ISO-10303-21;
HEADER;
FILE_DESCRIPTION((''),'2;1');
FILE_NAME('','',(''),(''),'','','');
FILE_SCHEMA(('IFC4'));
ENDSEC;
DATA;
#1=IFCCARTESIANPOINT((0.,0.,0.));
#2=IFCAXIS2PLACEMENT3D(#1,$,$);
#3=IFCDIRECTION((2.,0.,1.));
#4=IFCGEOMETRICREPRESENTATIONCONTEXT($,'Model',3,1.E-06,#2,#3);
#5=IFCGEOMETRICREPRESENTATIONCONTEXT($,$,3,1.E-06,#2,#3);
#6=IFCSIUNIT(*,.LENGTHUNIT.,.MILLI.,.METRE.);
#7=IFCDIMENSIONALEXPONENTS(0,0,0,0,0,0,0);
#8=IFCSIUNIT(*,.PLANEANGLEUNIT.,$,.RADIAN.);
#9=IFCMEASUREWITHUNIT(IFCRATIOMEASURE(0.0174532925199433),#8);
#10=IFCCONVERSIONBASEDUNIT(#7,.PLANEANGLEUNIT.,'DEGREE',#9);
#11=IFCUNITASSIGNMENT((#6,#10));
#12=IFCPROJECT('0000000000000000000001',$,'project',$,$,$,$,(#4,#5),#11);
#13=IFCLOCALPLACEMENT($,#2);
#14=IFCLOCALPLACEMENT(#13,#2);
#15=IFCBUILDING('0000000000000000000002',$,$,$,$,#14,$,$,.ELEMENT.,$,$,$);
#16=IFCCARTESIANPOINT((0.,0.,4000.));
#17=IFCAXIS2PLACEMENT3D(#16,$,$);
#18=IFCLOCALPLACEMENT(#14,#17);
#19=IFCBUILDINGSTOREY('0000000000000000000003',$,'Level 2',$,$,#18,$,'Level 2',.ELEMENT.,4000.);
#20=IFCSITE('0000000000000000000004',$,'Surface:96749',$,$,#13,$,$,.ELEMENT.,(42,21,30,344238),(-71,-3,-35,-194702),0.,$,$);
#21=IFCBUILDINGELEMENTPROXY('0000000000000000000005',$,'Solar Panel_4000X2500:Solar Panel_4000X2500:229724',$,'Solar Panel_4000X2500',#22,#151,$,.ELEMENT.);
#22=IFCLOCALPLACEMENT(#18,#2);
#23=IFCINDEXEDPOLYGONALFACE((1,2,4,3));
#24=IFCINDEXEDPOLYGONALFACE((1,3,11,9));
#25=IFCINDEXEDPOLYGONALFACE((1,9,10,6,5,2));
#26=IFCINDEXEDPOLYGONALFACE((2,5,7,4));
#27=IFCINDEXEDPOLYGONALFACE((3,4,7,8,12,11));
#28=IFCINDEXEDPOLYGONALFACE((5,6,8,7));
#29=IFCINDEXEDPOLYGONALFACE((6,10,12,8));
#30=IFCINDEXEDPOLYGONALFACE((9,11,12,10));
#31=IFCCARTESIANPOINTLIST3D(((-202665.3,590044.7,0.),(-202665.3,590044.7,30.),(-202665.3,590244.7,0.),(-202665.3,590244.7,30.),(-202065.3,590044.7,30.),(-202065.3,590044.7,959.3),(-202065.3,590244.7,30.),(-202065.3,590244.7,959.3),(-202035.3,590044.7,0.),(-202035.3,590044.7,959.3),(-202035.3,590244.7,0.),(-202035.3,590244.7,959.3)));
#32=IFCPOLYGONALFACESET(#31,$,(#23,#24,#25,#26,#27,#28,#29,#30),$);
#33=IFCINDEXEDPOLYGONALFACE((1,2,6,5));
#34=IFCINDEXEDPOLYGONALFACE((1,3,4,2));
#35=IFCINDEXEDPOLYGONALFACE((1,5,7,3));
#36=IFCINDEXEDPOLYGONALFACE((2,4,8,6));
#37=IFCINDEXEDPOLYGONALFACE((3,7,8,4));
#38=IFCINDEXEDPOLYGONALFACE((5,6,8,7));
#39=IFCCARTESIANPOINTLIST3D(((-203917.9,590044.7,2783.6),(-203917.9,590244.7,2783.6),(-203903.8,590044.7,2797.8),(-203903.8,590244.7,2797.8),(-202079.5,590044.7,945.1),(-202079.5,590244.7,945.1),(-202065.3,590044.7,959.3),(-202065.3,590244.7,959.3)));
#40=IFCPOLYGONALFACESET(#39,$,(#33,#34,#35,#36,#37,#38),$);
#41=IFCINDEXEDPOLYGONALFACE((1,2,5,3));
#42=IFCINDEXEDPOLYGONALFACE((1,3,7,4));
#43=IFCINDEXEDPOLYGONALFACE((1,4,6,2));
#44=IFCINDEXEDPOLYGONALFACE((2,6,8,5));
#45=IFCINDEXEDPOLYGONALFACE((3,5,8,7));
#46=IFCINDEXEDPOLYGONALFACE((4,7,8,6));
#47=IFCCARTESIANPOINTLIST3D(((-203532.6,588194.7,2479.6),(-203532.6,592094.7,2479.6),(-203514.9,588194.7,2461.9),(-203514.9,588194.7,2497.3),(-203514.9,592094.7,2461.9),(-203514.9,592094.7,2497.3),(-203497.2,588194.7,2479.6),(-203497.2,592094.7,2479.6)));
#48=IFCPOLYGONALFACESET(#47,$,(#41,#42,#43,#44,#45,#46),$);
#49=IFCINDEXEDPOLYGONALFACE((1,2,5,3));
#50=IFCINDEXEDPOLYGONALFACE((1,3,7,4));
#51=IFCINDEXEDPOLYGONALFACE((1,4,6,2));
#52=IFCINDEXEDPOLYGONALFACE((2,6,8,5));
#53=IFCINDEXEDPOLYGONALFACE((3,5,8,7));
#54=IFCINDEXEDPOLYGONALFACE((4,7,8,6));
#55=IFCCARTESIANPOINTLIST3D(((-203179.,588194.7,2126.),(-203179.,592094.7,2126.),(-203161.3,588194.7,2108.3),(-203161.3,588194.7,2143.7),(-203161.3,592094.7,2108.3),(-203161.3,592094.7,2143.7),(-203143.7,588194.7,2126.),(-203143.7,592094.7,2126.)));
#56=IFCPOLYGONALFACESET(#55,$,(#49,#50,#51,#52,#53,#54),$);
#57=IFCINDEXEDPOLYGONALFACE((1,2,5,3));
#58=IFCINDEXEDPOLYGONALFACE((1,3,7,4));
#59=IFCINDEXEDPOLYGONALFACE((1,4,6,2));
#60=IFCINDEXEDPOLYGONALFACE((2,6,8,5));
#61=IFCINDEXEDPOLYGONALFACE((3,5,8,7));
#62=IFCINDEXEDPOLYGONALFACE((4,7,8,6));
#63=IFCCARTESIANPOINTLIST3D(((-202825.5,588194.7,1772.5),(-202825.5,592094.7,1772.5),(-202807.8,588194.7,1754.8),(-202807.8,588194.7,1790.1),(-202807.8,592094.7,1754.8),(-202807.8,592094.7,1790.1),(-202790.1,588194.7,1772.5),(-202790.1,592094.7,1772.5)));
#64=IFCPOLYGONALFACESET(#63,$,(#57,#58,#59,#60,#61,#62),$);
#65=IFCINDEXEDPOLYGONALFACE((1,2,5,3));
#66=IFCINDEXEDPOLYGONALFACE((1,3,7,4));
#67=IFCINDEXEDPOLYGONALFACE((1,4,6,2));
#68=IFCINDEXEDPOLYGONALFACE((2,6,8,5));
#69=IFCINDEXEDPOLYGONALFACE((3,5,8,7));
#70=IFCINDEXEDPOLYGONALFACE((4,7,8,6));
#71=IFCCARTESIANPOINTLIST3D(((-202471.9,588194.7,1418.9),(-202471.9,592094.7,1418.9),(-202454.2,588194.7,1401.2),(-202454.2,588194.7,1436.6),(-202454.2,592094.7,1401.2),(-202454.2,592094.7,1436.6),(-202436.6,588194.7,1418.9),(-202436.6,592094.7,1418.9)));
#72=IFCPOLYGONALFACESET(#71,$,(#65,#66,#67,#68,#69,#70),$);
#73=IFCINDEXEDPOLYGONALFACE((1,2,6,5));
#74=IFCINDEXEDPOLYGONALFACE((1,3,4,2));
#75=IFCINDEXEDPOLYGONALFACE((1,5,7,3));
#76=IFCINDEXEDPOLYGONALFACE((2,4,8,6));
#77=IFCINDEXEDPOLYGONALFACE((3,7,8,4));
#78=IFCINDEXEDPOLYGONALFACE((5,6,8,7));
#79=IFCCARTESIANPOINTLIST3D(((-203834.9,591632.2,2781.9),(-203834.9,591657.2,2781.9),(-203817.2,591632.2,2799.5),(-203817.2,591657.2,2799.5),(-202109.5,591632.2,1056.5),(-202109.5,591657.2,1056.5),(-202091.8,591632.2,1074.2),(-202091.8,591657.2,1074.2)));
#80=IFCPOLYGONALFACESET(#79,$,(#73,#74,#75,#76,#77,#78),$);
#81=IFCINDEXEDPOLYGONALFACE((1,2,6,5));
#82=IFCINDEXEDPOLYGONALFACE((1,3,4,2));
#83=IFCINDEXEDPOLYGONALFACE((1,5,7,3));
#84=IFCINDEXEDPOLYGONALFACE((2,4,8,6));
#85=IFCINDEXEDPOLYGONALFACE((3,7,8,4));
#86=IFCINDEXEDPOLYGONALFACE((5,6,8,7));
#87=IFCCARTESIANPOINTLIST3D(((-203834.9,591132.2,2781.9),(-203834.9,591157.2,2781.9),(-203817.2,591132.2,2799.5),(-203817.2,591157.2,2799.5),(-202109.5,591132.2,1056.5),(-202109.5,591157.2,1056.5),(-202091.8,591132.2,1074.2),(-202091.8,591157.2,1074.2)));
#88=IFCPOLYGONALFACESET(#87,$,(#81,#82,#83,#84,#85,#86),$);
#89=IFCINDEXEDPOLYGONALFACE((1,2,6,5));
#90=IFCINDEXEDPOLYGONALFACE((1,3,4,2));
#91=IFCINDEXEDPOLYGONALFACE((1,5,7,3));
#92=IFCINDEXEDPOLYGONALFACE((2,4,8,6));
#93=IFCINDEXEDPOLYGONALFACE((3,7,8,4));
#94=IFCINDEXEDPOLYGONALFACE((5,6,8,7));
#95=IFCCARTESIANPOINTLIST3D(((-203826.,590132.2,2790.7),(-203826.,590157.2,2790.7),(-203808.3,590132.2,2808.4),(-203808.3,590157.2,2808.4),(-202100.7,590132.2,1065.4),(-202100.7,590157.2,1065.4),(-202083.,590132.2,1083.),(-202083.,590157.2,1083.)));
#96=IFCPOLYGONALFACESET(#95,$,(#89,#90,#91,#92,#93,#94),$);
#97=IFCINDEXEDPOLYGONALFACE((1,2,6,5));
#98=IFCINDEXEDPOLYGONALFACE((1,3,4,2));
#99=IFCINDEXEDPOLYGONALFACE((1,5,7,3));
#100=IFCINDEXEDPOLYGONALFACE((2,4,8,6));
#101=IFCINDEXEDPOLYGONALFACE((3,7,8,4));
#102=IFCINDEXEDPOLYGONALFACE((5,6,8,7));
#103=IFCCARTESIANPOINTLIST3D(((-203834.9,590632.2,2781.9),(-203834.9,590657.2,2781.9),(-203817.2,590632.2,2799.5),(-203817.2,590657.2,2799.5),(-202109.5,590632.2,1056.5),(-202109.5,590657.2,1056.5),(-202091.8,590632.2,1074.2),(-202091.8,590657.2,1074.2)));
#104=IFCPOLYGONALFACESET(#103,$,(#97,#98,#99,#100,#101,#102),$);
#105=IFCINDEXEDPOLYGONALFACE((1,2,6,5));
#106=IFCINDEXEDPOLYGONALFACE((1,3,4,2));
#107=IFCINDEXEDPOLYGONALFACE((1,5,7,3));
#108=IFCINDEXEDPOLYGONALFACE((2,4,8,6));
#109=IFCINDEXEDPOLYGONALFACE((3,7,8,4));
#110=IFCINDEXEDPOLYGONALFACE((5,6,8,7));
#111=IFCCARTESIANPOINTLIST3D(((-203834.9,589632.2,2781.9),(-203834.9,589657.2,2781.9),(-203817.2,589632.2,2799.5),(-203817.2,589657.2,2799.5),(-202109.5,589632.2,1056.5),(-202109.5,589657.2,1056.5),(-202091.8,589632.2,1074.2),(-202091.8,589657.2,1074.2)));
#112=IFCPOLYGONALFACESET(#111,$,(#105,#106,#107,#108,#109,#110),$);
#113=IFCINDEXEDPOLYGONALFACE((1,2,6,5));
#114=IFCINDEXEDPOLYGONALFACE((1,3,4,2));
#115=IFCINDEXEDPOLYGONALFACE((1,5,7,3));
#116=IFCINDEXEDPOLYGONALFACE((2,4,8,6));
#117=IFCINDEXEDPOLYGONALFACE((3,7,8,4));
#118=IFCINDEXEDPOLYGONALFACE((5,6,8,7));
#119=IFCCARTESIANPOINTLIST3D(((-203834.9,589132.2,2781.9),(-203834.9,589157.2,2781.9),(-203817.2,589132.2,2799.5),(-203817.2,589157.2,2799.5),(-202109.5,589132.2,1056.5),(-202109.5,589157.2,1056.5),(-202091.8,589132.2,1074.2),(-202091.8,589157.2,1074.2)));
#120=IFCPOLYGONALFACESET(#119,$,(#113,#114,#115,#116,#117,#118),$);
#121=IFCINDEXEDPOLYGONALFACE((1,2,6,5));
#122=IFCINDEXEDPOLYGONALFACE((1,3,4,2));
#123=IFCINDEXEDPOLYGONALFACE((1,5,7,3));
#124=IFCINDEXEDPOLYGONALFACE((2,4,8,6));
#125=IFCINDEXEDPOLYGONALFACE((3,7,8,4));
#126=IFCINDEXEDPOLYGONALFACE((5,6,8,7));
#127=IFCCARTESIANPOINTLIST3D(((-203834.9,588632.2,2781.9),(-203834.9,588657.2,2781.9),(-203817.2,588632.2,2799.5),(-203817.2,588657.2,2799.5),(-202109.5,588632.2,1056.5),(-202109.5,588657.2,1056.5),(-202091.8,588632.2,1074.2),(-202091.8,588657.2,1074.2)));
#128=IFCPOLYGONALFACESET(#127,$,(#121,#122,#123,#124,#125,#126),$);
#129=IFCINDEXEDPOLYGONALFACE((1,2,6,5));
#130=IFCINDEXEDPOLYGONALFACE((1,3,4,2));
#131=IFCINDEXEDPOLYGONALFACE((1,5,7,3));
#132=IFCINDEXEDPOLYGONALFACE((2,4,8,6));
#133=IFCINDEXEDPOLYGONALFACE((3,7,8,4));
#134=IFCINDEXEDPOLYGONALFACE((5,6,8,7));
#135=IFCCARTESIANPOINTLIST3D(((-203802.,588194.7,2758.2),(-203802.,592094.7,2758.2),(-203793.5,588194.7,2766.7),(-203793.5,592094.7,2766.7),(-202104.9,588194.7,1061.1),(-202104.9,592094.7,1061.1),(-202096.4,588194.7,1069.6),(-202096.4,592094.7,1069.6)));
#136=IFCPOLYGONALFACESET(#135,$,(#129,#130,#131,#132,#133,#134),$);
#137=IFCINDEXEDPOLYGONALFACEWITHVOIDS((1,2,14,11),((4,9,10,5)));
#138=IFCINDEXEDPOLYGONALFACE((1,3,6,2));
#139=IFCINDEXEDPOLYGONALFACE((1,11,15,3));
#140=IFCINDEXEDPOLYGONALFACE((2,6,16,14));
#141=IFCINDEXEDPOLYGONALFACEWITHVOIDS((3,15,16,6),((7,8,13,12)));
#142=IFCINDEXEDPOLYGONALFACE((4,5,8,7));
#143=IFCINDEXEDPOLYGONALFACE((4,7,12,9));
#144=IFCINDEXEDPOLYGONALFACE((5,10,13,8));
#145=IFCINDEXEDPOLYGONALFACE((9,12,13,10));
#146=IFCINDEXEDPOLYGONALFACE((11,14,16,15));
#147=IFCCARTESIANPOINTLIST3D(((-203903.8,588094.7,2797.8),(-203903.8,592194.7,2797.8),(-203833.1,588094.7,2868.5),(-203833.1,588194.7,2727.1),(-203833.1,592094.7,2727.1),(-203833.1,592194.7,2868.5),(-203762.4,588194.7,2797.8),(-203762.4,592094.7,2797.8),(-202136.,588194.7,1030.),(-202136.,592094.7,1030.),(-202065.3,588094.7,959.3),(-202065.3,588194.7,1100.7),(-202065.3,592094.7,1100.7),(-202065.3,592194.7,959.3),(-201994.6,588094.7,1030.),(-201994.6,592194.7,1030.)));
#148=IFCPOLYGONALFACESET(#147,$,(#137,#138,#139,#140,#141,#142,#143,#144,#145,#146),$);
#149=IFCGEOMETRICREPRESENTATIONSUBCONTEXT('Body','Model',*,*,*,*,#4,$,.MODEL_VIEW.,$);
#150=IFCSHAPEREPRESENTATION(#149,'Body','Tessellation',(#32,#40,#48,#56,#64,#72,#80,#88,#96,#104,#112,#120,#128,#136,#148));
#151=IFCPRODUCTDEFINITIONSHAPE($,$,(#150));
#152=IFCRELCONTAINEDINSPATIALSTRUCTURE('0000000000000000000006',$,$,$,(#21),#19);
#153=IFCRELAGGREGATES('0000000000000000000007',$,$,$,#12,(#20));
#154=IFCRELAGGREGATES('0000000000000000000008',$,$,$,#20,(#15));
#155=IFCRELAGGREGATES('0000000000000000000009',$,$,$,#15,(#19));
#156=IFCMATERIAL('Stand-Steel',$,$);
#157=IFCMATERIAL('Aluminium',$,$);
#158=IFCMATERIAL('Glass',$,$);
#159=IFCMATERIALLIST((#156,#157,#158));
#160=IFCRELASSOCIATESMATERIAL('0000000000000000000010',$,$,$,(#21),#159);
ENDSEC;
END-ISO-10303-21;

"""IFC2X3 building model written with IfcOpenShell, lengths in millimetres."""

from ifc_helpers import new_model, entity, si_unit, converted_unit, direction, frame, frame_2d, origin, origin_2d_with_axis, place, context, subcontext, project, spatial, polyline, rectangle, outline, extrude, source, transform, mapped, material, material_list, element, save


model = new_model("IFC2X3")

# Units and contexts
model_context = context("Model", 3, precision=1e-06, world=origin(), true_north=direction((2.0, 0.0, 1.0)))
context_of_model = context(None, 3, precision=1e-06, world=origin(), true_north=direction((2.0, 0.0, 1.0)))
body_context = subcontext(model_context, "Body", "Model", "MODEL_VIEW")
ifc_project = project(units=[si_unit("LENGTHUNIT", "METRE", prefix="MILLI"), converted_unit("PLANEANGLEUNIT", "DEGREE", entity("IfcRatioMeasure", 0.0174532925199433), si_unit("PLANEANGLEUNIT", "RADIAN"), dimensions=[0, 0, 0, 0, 0, 0, 0])], contexts=[model_context, context_of_model])

# Site, building, storey
site_placement = place(None, origin())
site = spatial("IfcSite", under=ifc_project, at=site_placement, Name="Surface:96749", CompositionType="ELEMENT", RefLatitude=(42, 21, 30, 344238), RefLongitude=(-71, -3, -35, -194702), RefElevation=0.0)
building_placement = place(site_placement, origin())
building = spatial("IfcBuilding", under=site, at=building_placement, CompositionType="ELEMENT")
storey_placement = place(building_placement, frame((0.0, 0.0, 4000.0)))
storey = spatial("IfcBuildingStorey", under=building, at=storey_placement, Name="Level 2", LongName="Level 2", CompositionType="ELEMENT", Elevation=4000.0)

# Building element proxy
ifc_material_1 = material(Name="Stand-Steel")
ifc_material_2 = material(Name="Aluminium")
ifc_material_3 = material(Name="Glass")
shared_shape = source(origin(), body_context, "Body", "SweptSolid", [
    extrude(outline(polyline([(-629.5, -220.0), (329.8, -220.0), (329.8, 410.0), (299.8, 410.0), (299.8, -190.0), (-629.5, -190.0), (-629.5, -220.0)])), frame((-190.0, -100.0, 299.8), z_axis=(0.0, 1.0, 0.0), x_axis=(0.0, 0.0, -1.0)), (0.0, 0.0, 1.0), 200.0),
    extrude(rectangle(XDim=20.0, YDim=200.0, at=frame_2d((0.0, 0.0), x_axis=(0.0, 1.0))), frame((-7.1, 0.0, 922.2), z_axis=(-0.707107, 0.0, 0.707107), x_axis=(0.0, 1.0, 0.0)), (0.0, 0.0, 1.0), 2600.0),
    extrude(rectangle(XDim=25.0, YDim=25.0, at=frame_2d((0.0, 0.0), x_axis=(1.0, 0.0))), frame((-1449.6, -1950.0, 2449.6), z_axis=(0.0, 1.0, 0.0), x_axis=(-0.707107, 0.0, -0.707107)), (0.0, 0.0, 1.0), 3900.0),
    extrude(rectangle(XDim=25.0, YDim=25.0, at=origin_2d_with_axis()), frame((-1096.0, -1950.0, 2096.0), z_axis=(0.0, 1.0, 0.0), x_axis=(-0.707107, 0.0, -0.707107)), (0.0, 0.0, 1.0), 3900.0),
    extrude(rectangle(XDim=25.0, YDim=25.0, at=origin_2d_with_axis()), frame((-742.5, -1950.0, 1742.5), z_axis=(0.0, 1.0, 0.0), x_axis=(-0.707107, 0.0, -0.707107)), (0.0, 0.0, 1.0), 3900.0),
    extrude(rectangle(XDim=25.0, YDim=25.0, at=frame_2d((0.0, 0.0), x_axis=(1.0, 0.0))), frame((-388.9, -1950.0, 1388.9), z_axis=(0.0, 1.0, 0.0), x_axis=(-0.707107, 0.0, -0.707107)), (0.0, 0.0, 1.0), 3900.0),
    extrude(rectangle(XDim=25.0, YDim=25.0, at=frame_2d((0.0, 0.0), x_axis=(0.0, 1.0))), frame((-35.4, 1500.0, 1035.4), z_axis=(-0.707107, 0.0, 0.707107), x_axis=(0.0, 1.0, 0.0)), (0.0, 0.0, 1.0), 2440.0),
    extrude(rectangle(XDim=25.0, YDim=25.0, at=frame_2d((0.0, 0.0), x_axis=(0.0, 1.0))), frame((-35.4, 1000.0, 1035.4), z_axis=(-0.707107, 0.0, 0.707107), x_axis=(0.0, 1.0, 0.0)), (0.0, 0.0, 1.0), 2440.0),
    extrude(rectangle(XDim=25.0, YDim=25.0, at=frame_2d((0.0, 0.0), x_axis=(0.0, 1.0))), frame((-26.5, 0.0, 1044.2), z_axis=(-0.707107, 0.0, 0.707107), x_axis=(0.0, -1.0, 0.0)), (0.0, 0.0, 1.0), 2440.0),
    extrude(rectangle(XDim=25.0, YDim=25.0, at=frame_2d((0.0, 0.0), x_axis=(0.0, 1.0))), frame((-35.4, 500.0, 1035.4), z_axis=(-0.707107, 0.0, 0.707107), x_axis=(0.0, 1.0, 0.0)), (0.0, 0.0, 1.0), 2440.0),
    extrude(rectangle(XDim=25.0, YDim=25.0, at=frame_2d((0.0, 0.0), x_axis=(0.0, 1.0))), frame((-35.4, -500.0, 1035.4), z_axis=(-0.707107, 0.0, 0.707107), x_axis=(0.0, 1.0, 0.0)), (0.0, 0.0, 1.0), 2440.0),
    extrude(rectangle(XDim=25.0, YDim=25.0, at=frame_2d((0.0, 0.0), x_axis=(0.0, 1.0))), frame((-35.4, -1000.0, 1035.4), z_axis=(-0.707107, 0.0, 0.707107), x_axis=(0.0, 1.0, 0.0)), (0.0, 0.0, 1.0), 2440.0),
    extrude(rectangle(XDim=25.0, YDim=25.0, at=frame_2d((0.0, 0.0), x_axis=(0.0, 1.0))), frame((-35.4, -1500.0, 1035.4), z_axis=(-0.707107, 0.0, 0.707107), x_axis=(0.0, 1.0, 0.0)), (0.0, 0.0, 1.0), 2440.0),
    extrude(rectangle(XDim=2400.0, YDim=12.0, at=frame_2d((0.0, 0.0), x_axis=(1.0, 0.0))), frame((-883.9, -1950.0, 1883.9), z_axis=(0.0, 1.0, 0.0), x_axis=(0.707107, 0.0, -0.707107)), (0.0, 0.0, 1.0), 3900.0),
    extrude(outline(polyline([(-2050.0, -1300.0), (2050.0, -1300.0), (2050.0, 1300.0), (-2050.0, 1300.0), (-2050.0, -1300.0)]), holes=[polyline([(1950.0, -1200.0), (-1950.0, -1200.0), (-1950.0, 1200.0), (1950.0, 1200.0), (1950.0, -1200.0)])]), frame((-919.2, 0.0, 1848.5), z_axis=(0.707107, 0.0, 0.707107), x_axis=(0.0, 1.0, 0.0)), (0.0, 0.0, 1.0), 100.0),
])
ifc_material_list_1 = material_list([ifc_material_1, ifc_material_2, ifc_material_3])
proxy_1_placement = place(storey_placement, frame((-202065.3, 590144.7, 30.0)))
element("IfcBuildingElementProxy", 1, at=proxy_1_placement, inside=storey, material=ifc_material_list_1, Name="Solar Panel_4000X2500:Solar Panel_4000X2500:229724", ObjectType="Solar Panel_4000X2500", CompositionType="ELEMENT", context=body_context, shape_type="MappedRepresentation", body=[
    mapped(shared_shape, transform((0.0, 0.0, 0.0), scale=1.0)),
])

save(model, "model.ifc")
